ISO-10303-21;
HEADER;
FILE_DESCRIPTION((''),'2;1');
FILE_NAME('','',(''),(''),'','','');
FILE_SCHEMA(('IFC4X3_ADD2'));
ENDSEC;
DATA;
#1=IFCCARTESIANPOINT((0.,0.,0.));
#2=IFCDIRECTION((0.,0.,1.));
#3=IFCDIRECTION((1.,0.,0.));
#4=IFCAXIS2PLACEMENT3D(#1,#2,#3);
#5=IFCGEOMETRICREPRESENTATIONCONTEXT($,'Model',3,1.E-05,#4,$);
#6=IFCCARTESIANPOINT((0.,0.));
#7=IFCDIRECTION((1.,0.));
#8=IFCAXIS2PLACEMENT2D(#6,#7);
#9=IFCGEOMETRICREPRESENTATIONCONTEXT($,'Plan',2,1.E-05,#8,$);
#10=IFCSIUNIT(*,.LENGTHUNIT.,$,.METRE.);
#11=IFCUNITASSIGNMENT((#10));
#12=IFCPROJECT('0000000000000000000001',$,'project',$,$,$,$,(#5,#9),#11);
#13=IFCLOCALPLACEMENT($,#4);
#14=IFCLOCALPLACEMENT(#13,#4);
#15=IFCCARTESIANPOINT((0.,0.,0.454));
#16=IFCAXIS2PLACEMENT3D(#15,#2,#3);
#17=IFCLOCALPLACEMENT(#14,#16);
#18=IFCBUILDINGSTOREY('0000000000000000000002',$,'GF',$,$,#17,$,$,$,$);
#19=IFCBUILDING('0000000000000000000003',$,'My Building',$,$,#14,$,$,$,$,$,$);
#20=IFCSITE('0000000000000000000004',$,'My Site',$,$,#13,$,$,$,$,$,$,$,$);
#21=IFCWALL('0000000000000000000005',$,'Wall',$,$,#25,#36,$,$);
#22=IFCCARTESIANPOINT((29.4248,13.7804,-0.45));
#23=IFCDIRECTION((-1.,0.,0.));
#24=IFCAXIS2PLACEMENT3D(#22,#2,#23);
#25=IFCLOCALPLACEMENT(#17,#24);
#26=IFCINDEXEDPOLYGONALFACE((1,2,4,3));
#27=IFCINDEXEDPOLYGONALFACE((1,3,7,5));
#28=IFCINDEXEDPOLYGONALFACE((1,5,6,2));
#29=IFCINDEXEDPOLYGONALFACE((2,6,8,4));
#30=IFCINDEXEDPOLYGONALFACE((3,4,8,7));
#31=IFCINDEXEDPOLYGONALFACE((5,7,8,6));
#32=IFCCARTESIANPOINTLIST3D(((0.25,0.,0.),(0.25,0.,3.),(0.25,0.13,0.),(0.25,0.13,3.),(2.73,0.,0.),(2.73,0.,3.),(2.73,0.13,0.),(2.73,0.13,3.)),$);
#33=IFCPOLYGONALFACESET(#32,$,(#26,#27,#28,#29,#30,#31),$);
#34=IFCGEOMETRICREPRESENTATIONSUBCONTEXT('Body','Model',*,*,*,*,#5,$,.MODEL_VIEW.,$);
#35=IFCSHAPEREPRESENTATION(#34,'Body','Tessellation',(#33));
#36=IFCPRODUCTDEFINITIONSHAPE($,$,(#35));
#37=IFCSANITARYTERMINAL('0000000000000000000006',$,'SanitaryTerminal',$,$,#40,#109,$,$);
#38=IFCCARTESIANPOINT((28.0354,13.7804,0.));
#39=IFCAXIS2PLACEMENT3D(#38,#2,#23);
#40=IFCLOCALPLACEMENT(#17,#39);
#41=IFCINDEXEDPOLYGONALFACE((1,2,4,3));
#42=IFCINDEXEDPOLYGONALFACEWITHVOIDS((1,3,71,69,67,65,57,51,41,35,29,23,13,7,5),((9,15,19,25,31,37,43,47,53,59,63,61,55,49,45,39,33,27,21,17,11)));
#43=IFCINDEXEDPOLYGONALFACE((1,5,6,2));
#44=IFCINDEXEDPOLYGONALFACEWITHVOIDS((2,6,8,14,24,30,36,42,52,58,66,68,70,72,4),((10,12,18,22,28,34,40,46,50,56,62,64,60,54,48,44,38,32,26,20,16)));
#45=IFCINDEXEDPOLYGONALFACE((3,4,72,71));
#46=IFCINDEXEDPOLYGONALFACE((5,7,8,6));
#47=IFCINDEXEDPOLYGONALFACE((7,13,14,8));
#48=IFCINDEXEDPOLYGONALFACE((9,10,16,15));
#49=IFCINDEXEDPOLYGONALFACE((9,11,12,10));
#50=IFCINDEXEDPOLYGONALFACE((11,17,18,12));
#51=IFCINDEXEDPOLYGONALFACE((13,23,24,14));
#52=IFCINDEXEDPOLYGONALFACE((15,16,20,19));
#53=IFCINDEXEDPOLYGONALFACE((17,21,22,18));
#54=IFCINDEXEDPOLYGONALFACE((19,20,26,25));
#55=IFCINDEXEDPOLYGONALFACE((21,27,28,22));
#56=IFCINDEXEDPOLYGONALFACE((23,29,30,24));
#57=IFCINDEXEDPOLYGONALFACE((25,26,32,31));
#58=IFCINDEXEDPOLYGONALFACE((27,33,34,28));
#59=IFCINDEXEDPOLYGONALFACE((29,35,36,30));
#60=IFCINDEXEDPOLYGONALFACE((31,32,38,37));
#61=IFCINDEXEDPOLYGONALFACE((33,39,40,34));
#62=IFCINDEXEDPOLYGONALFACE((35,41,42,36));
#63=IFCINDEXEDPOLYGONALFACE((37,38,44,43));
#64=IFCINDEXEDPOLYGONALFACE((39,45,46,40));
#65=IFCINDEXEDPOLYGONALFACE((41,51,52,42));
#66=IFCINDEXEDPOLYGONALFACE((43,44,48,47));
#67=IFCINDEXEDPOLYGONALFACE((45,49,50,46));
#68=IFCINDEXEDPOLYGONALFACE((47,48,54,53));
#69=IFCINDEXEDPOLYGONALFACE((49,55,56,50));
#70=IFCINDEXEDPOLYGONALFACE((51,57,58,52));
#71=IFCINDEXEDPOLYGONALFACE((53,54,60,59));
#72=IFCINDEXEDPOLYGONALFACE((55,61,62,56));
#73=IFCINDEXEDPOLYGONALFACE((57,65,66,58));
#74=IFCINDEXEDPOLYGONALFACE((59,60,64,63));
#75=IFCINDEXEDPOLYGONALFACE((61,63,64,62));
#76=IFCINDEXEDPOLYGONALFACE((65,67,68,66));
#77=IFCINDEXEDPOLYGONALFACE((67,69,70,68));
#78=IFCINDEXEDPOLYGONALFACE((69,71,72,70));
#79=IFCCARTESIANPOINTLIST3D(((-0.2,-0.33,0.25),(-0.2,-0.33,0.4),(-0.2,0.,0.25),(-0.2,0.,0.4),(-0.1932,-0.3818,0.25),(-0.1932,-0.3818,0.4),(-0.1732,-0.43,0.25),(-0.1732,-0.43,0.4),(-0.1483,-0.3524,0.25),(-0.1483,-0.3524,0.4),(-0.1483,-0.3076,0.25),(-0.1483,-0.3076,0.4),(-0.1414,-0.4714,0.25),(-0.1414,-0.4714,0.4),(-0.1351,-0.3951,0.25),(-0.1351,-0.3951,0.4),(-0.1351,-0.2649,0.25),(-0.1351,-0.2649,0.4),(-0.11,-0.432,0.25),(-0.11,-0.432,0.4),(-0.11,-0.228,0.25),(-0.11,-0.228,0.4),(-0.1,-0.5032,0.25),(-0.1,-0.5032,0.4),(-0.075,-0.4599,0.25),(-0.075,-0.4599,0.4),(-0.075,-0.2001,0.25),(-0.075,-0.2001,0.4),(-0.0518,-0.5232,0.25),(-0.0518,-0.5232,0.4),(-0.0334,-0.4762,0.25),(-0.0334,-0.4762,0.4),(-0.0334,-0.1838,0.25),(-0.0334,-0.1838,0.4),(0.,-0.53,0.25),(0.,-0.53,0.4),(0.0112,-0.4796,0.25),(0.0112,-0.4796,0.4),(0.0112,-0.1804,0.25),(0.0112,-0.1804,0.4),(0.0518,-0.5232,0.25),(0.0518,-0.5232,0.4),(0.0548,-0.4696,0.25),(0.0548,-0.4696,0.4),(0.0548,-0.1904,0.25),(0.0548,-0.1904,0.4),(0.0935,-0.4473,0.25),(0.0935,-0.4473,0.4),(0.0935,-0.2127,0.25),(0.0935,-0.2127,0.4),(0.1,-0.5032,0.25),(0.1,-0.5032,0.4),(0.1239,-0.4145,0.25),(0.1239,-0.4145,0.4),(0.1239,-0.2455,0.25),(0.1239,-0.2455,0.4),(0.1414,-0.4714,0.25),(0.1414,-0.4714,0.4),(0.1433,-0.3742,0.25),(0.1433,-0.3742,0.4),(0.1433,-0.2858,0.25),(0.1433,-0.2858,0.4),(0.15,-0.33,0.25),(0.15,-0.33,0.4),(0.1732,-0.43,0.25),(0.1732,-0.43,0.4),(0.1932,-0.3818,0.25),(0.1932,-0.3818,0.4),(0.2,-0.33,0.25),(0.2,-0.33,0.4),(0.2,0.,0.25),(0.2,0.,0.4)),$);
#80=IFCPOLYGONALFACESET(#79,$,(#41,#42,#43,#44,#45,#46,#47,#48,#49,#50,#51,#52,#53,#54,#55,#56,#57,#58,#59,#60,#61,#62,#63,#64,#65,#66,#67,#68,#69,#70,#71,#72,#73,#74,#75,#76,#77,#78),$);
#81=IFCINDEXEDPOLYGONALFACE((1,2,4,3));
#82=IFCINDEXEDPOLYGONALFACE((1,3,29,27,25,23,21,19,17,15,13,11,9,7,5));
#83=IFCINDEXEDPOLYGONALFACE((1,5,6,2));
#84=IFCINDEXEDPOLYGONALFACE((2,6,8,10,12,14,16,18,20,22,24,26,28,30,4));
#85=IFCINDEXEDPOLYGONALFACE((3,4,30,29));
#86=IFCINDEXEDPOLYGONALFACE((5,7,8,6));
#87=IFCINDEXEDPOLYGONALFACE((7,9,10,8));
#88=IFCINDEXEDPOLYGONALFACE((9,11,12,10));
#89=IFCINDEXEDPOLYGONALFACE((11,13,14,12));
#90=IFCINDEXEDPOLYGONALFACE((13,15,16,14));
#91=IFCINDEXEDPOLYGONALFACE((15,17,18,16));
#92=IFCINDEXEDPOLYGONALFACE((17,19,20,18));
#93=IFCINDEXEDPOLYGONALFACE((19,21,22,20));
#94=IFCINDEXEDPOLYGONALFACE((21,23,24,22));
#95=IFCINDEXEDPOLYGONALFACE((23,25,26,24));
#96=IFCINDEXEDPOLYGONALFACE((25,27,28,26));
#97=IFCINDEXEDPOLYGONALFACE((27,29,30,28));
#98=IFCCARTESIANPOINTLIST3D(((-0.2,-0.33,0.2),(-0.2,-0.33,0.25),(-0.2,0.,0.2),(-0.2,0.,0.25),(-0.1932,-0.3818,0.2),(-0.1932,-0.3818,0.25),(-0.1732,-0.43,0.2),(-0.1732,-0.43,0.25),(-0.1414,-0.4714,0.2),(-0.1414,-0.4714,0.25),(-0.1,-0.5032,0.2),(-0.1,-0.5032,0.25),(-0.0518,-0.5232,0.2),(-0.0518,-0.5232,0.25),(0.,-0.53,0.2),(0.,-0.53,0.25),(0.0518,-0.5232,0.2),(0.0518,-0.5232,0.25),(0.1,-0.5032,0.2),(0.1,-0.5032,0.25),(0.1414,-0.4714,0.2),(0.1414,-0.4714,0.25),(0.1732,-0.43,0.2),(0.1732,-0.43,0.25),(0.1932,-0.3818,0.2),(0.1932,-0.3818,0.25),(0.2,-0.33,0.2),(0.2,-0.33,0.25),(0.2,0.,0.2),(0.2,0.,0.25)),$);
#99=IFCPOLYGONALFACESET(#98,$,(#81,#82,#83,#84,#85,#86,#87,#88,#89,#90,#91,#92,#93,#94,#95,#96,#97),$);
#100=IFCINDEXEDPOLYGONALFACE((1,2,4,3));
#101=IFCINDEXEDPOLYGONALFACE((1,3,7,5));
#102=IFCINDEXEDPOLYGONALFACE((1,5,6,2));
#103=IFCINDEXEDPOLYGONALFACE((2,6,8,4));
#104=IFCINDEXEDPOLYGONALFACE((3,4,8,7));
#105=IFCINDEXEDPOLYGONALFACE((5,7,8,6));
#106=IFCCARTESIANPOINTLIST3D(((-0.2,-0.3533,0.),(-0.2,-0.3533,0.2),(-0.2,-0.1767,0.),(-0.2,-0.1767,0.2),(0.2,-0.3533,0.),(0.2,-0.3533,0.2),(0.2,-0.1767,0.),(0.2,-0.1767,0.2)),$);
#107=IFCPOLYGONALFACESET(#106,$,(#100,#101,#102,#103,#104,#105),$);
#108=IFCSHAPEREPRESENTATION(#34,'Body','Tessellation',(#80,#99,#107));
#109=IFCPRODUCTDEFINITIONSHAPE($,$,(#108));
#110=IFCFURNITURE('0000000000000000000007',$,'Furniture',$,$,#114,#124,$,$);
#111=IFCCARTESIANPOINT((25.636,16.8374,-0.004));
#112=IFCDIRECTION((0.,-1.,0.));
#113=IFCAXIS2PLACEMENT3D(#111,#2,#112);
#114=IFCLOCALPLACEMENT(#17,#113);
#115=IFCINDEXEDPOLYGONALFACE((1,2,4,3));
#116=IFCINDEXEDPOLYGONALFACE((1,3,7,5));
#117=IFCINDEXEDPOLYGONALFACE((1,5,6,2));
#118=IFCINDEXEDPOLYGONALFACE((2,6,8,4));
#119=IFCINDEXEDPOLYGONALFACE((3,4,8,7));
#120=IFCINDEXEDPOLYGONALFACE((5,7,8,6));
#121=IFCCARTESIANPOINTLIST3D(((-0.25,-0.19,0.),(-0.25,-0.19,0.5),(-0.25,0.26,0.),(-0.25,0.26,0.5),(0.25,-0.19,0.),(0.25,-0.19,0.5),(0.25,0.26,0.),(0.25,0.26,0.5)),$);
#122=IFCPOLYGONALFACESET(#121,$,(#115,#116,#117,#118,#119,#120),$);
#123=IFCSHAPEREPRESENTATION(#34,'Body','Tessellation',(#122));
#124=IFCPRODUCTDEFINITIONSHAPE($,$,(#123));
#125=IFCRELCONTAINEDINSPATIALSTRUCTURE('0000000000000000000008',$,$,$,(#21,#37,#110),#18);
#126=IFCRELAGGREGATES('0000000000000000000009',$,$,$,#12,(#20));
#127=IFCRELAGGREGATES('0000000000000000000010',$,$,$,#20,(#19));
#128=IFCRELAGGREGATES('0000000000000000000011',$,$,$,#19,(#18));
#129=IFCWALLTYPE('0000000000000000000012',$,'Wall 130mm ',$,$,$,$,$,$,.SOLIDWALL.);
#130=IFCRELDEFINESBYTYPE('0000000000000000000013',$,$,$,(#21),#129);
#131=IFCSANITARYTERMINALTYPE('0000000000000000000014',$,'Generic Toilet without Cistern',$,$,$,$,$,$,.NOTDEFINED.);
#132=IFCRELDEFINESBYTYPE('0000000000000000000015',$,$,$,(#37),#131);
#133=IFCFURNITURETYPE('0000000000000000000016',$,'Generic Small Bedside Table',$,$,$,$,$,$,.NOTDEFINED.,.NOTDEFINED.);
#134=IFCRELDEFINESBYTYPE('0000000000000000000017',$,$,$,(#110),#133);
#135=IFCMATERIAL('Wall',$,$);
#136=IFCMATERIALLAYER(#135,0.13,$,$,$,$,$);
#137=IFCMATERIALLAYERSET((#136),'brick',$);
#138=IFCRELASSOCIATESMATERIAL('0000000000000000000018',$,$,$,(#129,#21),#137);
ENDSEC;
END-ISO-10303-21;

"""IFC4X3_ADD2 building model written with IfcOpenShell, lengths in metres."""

from ifc_helpers import new_model, entity, si_unit, frame, frame_2d, origin_with_axes, origin_2d_with_axis, place, context, subcontext, project, spatial, line, arc, indexed_curve, circle_curve, outline, extrude, shape, source, transform, mapped, material, layer, layer_set, layer_usage, type_object, type_shapes, element, save


model = new_model("IFC4X3_ADD2")

# Units and contexts
model_context = context("Model", 3, precision=1e-05, world=origin_with_axes())
plan_context = context("Plan", 2, precision=1e-05, world=origin_2d_with_axis())
body_context_1 = subcontext(model_context, "Body", "Model", "MODEL_VIEW")
body_context_2 = subcontext(plan_context, "Body", "Plan", "PLAN_VIEW")
ifc_project = project(units=[si_unit("LENGTHUNIT", "METRE")], contexts=[model_context, plan_context])

# Site, building, storey
site_placement = place(None, origin_with_axes())
site = spatial("IfcSite", under=ifc_project, at=site_placement, Name="My Site")
building_placement = place(site_placement, origin_with_axes())
building = spatial("IfcBuilding", under=site, at=building_placement, Name="My Building")
storey_placement = place(building_placement, frame((0.0, 0.0, 0.454), z_axis=(0.0, 0.0, 1.0), x_axis=(1.0, 0.0, 0.0)))
storey = spatial("IfcBuildingStorey", under=building, at=storey_placement, Name="GF")

# Wall
ifc_material_1 = material(Name="Wall")
ifc_layer_1 = layer(ifc_material_1, 0.13)
ifc_layer_set_1 = layer_set([ifc_layer_1], Name="brick")
ifc_layer_usage_1 = layer_usage(ifc_layer_set_1, "AXIS2", "POSITIVE", 0.0)
wall_type_1 = type_object("IfcWallType", Name="Wall 130mm ", PredefinedType="SOLIDWALL", material=ifc_layer_set_1)
wall_1_placement = place(storey_placement, frame((29.4248, 13.7804, -0.45), z_axis=(0.0, 0.0, 1.0), x_axis=(-1.0, 0.0, 0.0)))
element("IfcWall", 1, at=wall_1_placement, inside=storey, type_object=wall_type_1, material=ifc_layer_usage_1, Name="Wall", context=body_context_1, shape_type="SweptSolid", body=[
    extrude(outline(indexed_curve([(0.25, 0.0), (0.25, 0.13), (2.73, 0.13), (2.73, 0.0)], segments=[line(1, 2, 3, 4, 1)])), origin_with_axes(), (0.0, 0.0, 1.0), 3.0),
])

# Sanitary terminal
sanitary_terminal_type_1 = type_object("IfcSanitaryTerminalType", Name="Generic Toilet without Cistern", PredefinedType="NOTDEFINED")
shared_shape_1 = source(origin_with_axes(), body_context_1, "Body", "SweptSolid", [
    extrude(outline(indexed_curve([(-0.2, 0.0), (0.2, 0.0), (0.2, -0.33), (0.1414, -0.4714), (0.0, -0.53), (-0.1414, -0.4714), (-0.2, -0.33)], segments=[line(1, 2), line(2, 3), arc(3, 4, 5), arc(5, 6, 7), line(7, 1)]), holes=[circle_curve(frame_2d((0.0, -0.33)), 0.15)]), frame((0.0, 0.0, 0.25), z_axis=(0.0, 0.0, 1.0), x_axis=(1.0, 0.0, 0.0)), (0.0, 0.0, 1.0), 0.15),
    extrude(outline(indexed_curve([(-0.2, 0.0), (0.2, 0.0), (0.2, -0.33), (0.1414, -0.4714), (0.0, -0.53), (-0.1414, -0.4714), (-0.2, -0.33)], segments=[line(1, 2), line(2, 3), arc(3, 4, 5), arc(5, 6, 7), line(7, 1)])), frame((0.0, 0.0, 0.2), z_axis=(0.0, 0.0, 1.0), x_axis=(1.0, 0.0, 0.0)), (0.0, 0.0, 1.0), 0.05),
    extrude(outline(indexed_curve([(-0.2, -0.1767), (0.2, -0.1767), (0.2, -0.3533), (-0.2, -0.3533)], segments=[line(1, 2, 3, 4, 1)])), origin_with_axes(), (0.0, 0.0, 1.0), 0.2),
])
shared_shape_2 = source(origin_with_axes(), body_context_2, "Body", "Annotation2D", [
    entity("IfcGeometricCurveSet", [entity("IfcIndexedPolyCurve", entity("IfcCartesianPointList2D", [[-0.1068, -0.124], [-0.0957, -0.1129], [-0.0804, -0.1088], [0.0804, -0.1088], [0.0957, -0.1129], [0.1068, -0.124], [0.1109, -0.1393], [0.1109, -0.3476], [0.1025, -0.3926], [0.0784, -0.4308], [0.0424, -0.4563], [0.0, -0.4652], [-0.0424, -0.4563], [-0.0784, -0.4308], [-0.1025, -0.3926], [-0.1109, -0.3476], [-0.1109, -0.1393]]), [entity("IfcLineIndex", [1, 2, 3, 4, 5, 6, 7, 8, 9, 10, 11, 12, 13, 14, 15, 16, 17, 1])]), entity("IfcIndexedPolyCurve", entity("IfcCartesianPointList2D", [[-0.1962, -0.2314], [-0.1848, -0.301], [-0.1764, -0.3339], [-0.1663, -0.3651], [-0.1546, -0.3944], [-0.1414, -0.4213], [-0.1269, -0.4458], [-0.1111, -0.4675], [-0.0943, -0.4862], [-0.0765, -0.5018], [-0.0581, -0.514], [-0.039, -0.5229], [-0.0196, -0.5282], [0.0, -0.53], [0.0196, -0.5282], [0.039, -0.5229], [0.0581, -0.514], [0.0765, -0.5018], [0.0943, -0.4862], [0.1111, -0.4675], [0.1269, -0.4458], [0.1414, -0.4213], [0.1546, -0.3944], [0.1663, -0.3651], [0.1764, -0.3339], [0.1848, -0.301], [0.1962, -0.2314], [0.2, -0.159], [0.1872, 0.0], [-0.1872, 0.0], [-0.2, -0.159]]), [entity("IfcLineIndex", [1, 2, 3, 4, 5, 6, 7, 8, 9, 10, 11, 12, 13, 14, 15, 16, 17, 18, 19, 20, 21, 22, 23, 24, 25, 26, 27, 28, 29, 30, 31, 1])])]),
])
type_shapes(sanitary_terminal_type_1, [shared_shape_1, shared_shape_2])
sanitary_terminal_1_placement = place(storey_placement, frame((28.0354, 13.7804, 0.0), z_axis=(0.0, 0.0, 1.0), x_axis=(-1.0, 0.0, 0.0)))
element("IfcSanitaryTerminal", 2, at=sanitary_terminal_1_placement, inside=storey, type_object=sanitary_terminal_type_1, Name="SanitaryTerminal", shapes=[
    shape(body_context_1, "Body", "MappedRepresentation", [mapped(shared_shape_1, transform((0.0, 0.0, 0.0), x_axis=(1.0, 0.0, 0.0), y_axis=(0.0, 1.0, 0.0), z_axis=(0.0, 0.0, 1.0), scale=1.0))]),
    shape(body_context_2, "Body", "MappedRepresentation", [mapped(shared_shape_2, transform((0.0, 0.0, 0.0), x_axis=(1.0, 0.0, 0.0), y_axis=(0.0, 1.0, 0.0), z_axis=(0.0, 0.0, 1.0), scale=1.0))]),
])

# Furniture
furniture_type_1 = type_object("IfcFurnitureType", Name="Generic Small Bedside Table", AssemblyPlace="NOTDEFINED", PredefinedType="NOTDEFINED")
shared_shape_3 = source(origin_with_axes(), body_context_1, "Body", "SweptSolid", [
    extrude(outline(indexed_curve([(0.5, 0.45), (0.5, 0.0), (0.0, 0.0), (0.0, 0.45)], segments=[line(4, 1), line(1, 2), line(2, 3), line(3, 4)], self_intersect=False)), frame((-0.25, -0.19, 0.0), z_axis=(0.0, 0.0, 1.0), x_axis=(1.0, 0.0, 0.0)), (0.0, 0.0, 1.0), 0.5),
])
shared_shape_4 = source(origin_with_axes(), body_context_2, "Body", "Annotation2D", [
    entity("IfcGeometricCurveSet", [entity("IfcIndexedPolyCurve", entity("IfcCartesianPointList2D", [[-0.25, -0.19], [0.25, -0.19], [0.25, 0.26], [-0.25, 0.26]]), [entity("IfcLineIndex", [1, 2]), entity("IfcLineIndex", [2, 3]), entity("IfcLineIndex", [3, 4]), entity("IfcLineIndex", [4, 1])])]),
])
type_shapes(furniture_type_1, [shared_shape_3, shared_shape_4])
furniture_1_placement = place(storey_placement, frame((25.636, 16.8374, -0.004), z_axis=(0.0, 0.0, 1.0), x_axis=(0.0, -1.0, 0.0)))
element("IfcFurniture", 3, at=furniture_1_placement, inside=storey, type_object=furniture_type_1, Name="Furniture", shapes=[
    shape(body_context_1, "Body", "MappedRepresentation", [mapped(shared_shape_3, transform((0.0, 0.0, 0.0), x_axis=(1.0, 0.0, 0.0), y_axis=(0.0, 1.0, 0.0), z_axis=(0.0, 0.0, 1.0), scale=1.0))]),
    shape(body_context_2, "Body", "MappedRepresentation", [mapped(shared_shape_4, transform((0.0, 0.0, 0.0), x_axis=(1.0, 0.0, 0.0), y_axis=(0.0, 1.0, 0.0), z_axis=(0.0, 0.0, 1.0), scale=1.0))]),
])

save(model, "model.ifc")
